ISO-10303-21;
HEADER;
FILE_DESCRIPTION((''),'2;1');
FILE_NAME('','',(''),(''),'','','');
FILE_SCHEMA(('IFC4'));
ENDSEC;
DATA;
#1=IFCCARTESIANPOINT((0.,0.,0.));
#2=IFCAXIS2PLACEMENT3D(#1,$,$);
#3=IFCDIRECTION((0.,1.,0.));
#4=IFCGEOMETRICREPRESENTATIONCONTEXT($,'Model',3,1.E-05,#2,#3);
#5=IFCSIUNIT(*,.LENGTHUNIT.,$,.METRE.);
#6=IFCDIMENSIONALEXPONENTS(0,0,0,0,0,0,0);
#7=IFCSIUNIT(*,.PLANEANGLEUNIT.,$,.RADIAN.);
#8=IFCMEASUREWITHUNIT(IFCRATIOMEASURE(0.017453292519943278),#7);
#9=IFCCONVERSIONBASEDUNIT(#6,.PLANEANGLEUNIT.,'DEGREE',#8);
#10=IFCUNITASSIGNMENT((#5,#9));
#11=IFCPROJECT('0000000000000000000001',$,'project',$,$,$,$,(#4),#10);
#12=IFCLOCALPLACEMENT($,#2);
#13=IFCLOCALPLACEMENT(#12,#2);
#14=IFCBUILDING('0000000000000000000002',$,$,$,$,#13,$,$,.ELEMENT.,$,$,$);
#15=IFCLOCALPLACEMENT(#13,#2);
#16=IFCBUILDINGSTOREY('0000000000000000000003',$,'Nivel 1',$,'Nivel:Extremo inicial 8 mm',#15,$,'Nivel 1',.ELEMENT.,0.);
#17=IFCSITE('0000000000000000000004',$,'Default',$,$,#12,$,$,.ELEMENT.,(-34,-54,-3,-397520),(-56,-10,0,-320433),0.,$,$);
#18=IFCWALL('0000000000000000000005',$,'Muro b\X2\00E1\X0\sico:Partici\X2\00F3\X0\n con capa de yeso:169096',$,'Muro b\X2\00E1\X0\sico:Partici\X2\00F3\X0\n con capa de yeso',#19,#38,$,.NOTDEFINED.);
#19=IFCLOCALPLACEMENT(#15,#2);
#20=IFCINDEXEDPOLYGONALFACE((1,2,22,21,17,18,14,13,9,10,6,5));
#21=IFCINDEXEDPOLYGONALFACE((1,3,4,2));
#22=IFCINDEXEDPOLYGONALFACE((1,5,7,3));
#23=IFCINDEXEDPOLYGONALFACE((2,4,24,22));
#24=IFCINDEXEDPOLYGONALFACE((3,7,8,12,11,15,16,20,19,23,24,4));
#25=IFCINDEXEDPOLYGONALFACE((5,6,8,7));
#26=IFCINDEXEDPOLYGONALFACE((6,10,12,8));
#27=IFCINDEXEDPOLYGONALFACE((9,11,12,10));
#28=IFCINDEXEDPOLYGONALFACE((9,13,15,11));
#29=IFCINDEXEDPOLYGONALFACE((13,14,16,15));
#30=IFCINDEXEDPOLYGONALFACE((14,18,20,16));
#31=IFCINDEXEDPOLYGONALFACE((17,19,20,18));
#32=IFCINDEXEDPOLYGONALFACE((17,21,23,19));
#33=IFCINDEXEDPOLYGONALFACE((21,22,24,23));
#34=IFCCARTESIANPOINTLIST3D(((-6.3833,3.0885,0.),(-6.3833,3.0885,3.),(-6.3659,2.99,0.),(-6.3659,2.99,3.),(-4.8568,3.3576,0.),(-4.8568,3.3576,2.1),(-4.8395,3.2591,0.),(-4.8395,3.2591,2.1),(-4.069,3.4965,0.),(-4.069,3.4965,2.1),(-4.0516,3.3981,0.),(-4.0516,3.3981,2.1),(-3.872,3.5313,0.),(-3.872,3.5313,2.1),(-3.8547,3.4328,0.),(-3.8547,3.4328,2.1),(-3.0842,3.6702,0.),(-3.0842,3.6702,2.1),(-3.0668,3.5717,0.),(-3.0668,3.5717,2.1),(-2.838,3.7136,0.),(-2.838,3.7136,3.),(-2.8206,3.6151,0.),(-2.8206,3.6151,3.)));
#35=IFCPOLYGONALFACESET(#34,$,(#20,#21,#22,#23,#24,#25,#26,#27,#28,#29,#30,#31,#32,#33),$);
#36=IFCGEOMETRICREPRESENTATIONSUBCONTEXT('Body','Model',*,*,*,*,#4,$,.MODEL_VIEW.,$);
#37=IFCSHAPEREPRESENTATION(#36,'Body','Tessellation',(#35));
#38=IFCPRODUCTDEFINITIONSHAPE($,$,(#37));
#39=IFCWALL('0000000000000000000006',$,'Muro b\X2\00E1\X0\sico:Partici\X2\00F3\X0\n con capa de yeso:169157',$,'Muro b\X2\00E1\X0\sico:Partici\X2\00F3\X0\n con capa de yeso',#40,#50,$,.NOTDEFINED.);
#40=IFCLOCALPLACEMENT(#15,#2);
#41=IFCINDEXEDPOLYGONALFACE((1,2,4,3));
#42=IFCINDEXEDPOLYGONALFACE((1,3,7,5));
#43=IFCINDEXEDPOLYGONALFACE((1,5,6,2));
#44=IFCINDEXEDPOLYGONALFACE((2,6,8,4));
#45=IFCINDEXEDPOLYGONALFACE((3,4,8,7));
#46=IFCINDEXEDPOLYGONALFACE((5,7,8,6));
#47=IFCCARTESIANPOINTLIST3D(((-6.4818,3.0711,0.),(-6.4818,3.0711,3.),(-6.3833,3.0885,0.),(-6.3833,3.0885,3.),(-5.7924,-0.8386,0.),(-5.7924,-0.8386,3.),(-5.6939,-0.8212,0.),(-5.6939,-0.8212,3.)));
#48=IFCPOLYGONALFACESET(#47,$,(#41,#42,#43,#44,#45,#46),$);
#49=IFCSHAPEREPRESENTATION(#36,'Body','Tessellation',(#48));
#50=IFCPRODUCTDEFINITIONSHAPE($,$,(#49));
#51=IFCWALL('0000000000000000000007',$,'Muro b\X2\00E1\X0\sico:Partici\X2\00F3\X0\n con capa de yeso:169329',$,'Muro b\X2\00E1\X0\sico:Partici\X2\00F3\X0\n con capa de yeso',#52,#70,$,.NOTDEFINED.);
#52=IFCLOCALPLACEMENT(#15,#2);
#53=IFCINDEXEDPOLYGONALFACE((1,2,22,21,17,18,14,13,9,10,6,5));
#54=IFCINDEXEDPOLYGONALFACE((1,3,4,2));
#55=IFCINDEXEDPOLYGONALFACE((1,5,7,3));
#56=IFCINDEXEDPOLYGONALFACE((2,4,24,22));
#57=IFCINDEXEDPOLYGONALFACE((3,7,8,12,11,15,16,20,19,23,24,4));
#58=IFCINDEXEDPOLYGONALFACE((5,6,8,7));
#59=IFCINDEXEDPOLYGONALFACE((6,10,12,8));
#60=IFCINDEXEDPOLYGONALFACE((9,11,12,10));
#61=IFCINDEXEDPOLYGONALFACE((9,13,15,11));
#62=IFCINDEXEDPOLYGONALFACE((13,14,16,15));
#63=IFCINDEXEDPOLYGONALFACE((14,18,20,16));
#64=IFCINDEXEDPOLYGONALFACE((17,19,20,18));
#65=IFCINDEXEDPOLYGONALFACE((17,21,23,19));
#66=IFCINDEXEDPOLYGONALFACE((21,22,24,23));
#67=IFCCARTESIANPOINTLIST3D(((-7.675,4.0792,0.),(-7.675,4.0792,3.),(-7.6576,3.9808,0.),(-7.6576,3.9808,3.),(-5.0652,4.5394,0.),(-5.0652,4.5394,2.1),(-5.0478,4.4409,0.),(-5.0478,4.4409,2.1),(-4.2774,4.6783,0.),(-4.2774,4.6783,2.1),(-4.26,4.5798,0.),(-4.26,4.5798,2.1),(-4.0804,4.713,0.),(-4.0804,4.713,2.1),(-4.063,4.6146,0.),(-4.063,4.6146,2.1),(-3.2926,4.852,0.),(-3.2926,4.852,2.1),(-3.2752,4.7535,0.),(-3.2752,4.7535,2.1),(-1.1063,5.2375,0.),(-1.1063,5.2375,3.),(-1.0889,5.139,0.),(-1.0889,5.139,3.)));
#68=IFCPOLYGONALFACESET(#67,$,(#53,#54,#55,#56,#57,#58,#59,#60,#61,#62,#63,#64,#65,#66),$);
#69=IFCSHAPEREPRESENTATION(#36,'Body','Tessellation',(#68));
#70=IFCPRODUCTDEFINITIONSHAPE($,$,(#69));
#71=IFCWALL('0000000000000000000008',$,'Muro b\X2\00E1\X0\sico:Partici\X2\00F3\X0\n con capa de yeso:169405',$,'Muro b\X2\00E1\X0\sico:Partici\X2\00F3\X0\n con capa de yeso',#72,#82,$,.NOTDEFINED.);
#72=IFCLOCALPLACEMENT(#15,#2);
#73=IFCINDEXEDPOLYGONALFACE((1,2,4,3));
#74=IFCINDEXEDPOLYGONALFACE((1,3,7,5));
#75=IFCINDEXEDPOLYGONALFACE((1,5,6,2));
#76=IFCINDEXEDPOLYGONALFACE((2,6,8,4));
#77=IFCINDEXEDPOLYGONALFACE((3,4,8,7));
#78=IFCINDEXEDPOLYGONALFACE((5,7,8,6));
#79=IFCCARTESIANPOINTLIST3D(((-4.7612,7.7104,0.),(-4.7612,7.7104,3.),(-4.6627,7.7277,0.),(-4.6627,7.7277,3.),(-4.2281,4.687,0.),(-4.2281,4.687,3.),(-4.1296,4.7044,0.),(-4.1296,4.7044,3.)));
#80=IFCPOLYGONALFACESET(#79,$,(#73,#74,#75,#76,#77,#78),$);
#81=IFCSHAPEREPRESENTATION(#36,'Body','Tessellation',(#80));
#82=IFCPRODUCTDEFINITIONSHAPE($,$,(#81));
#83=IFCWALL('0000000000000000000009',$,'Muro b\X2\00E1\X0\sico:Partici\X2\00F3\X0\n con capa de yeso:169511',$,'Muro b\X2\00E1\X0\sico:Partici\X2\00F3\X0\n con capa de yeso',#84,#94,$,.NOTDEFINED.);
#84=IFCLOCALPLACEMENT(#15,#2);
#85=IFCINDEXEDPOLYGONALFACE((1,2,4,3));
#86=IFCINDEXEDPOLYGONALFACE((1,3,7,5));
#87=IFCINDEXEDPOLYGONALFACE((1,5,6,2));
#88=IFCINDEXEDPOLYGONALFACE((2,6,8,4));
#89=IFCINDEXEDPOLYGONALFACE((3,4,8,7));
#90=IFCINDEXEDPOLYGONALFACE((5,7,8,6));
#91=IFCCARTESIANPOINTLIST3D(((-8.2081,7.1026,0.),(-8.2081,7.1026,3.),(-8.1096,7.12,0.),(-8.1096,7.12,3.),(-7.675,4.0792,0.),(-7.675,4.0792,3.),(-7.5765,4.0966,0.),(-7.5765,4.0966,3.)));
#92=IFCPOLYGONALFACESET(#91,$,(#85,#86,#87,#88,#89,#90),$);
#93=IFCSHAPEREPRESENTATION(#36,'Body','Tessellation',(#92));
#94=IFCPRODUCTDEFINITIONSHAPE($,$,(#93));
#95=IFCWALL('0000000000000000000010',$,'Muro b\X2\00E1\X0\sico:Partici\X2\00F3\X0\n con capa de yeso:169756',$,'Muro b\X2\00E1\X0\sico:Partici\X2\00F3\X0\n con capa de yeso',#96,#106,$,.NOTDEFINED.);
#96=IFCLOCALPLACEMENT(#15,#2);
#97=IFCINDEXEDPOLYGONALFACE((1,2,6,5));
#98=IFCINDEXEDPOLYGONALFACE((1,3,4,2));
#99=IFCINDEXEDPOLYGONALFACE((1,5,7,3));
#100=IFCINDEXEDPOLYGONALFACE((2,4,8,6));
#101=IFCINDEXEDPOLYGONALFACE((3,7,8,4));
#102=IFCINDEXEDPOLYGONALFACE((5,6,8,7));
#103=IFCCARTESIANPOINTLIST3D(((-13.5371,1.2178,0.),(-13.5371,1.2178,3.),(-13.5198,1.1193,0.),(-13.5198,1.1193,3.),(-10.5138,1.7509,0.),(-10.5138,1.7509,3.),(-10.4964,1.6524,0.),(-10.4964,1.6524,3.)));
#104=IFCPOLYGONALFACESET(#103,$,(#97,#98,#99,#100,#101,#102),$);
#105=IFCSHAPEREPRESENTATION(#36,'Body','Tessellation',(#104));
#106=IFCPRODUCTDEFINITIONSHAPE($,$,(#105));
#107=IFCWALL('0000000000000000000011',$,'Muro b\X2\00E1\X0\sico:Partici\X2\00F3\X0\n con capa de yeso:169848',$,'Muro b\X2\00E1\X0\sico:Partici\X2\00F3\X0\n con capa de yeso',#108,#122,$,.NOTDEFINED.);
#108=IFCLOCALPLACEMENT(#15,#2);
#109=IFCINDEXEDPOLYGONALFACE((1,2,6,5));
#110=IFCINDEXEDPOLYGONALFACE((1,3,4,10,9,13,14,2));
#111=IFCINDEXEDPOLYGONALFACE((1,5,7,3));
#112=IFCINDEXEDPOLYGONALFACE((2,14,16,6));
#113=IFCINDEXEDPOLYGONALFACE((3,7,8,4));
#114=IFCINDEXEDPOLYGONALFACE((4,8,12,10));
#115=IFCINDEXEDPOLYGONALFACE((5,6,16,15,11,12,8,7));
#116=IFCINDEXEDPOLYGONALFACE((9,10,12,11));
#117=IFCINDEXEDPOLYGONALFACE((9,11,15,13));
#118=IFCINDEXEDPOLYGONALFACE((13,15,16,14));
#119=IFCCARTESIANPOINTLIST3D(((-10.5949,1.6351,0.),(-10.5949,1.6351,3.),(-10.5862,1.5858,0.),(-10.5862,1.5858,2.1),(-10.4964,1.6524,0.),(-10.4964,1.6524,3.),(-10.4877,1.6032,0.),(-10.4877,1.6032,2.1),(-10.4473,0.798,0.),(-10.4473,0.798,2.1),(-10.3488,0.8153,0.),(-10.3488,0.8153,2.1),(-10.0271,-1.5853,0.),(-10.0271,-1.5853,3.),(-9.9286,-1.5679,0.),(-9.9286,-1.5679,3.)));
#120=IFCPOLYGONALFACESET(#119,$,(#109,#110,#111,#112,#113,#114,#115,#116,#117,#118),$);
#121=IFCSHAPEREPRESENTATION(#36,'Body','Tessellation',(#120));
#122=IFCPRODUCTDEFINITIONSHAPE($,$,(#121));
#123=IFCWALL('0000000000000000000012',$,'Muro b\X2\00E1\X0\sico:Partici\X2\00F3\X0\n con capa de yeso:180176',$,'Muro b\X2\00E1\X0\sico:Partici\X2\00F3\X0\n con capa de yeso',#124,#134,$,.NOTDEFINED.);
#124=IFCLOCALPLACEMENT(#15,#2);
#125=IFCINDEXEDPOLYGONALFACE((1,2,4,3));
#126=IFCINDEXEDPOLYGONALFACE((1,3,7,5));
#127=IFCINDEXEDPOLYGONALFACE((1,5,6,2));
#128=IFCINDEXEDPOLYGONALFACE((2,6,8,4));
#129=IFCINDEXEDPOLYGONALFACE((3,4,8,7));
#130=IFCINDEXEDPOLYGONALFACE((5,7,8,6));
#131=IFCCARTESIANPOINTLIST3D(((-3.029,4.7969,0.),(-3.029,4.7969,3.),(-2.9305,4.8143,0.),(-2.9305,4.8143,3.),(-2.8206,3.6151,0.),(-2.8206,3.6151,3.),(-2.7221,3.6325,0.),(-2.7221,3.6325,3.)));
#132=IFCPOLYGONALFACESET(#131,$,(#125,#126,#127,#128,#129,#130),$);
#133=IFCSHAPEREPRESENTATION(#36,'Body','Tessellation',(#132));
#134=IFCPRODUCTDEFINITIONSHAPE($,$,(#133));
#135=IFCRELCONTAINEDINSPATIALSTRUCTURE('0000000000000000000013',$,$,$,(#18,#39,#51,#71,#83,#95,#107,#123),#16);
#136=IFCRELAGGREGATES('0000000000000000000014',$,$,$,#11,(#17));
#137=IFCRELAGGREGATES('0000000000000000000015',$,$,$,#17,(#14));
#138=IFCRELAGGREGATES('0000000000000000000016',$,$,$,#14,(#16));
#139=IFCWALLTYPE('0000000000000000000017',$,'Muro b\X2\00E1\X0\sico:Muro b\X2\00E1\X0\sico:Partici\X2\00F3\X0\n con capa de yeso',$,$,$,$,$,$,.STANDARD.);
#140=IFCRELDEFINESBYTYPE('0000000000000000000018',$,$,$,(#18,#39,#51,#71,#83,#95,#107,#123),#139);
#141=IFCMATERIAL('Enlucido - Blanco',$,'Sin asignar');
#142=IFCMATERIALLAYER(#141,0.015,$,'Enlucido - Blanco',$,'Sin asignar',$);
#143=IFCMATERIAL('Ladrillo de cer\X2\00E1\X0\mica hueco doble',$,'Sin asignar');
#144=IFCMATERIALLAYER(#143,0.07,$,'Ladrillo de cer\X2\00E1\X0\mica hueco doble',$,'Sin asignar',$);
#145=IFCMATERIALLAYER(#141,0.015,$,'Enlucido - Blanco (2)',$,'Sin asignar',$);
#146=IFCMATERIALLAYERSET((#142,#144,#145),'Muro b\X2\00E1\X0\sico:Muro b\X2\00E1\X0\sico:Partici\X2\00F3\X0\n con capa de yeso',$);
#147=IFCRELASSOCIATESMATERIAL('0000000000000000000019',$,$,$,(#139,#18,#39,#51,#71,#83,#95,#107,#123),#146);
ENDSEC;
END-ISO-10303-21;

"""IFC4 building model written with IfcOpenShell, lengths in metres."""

from ifc_helpers import new_model, entity, si_unit, converted_unit, direction, frame, frame_2d, origin, origin_2d_with_axis, place, context, subcontext, project, spatial, rectangle, extrude, material, layer, layer_set, layer_usage, type_object, element, save


model = new_model("IFC4")

# Units and contexts
model_context = context("Model", 3, precision=1e-05, world=origin(), true_north=direction((0.0, 1.0, 0.0)))
body_context = subcontext(model_context, "Body", "Model", "MODEL_VIEW")
ifc_project = project(units=[si_unit("LENGTHUNIT", "METRE"), converted_unit("PLANEANGLEUNIT", "DEGREE", entity("IfcRatioMeasure", 0.017453292519943278), si_unit("PLANEANGLEUNIT", "RADIAN"), dimensions=[0, 0, 0, 0, 0, 0, 0])], contexts=[model_context])

# Site, building, storey
site_placement = place(None, origin())
site = spatial("IfcSite", under=ifc_project, at=site_placement, Name="Default", CompositionType="ELEMENT", RefLatitude=(-34, -54, -3, -397520), RefLongitude=(-56, -10, 0, -320433), RefElevation=0.0)
building_placement = place(site_placement, origin())
building = spatial("IfcBuilding", under=site, at=building_placement, CompositionType="ELEMENT")
storey_placement = place(building_placement, origin())
storey = spatial("IfcBuildingStorey", under=building, at=storey_placement, Name="Nivel 1", ObjectType="Nivel:Extremo inicial 8 mm", LongName="Nivel 1", CompositionType="ELEMENT", Elevation=0.0)

# Shared definitions
ifc_material_1 = material(Name="Enlucido - Blanco", Category="Sin asignar")
ifc_layer_1 = layer(ifc_material_1, 0.015, Name="Enlucido - Blanco", Category="Sin asignar")
ifc_material_2 = material(Name="Ladrillo de cerámica hueco doble", Category="Sin asignar")
ifc_layer_2 = layer(ifc_material_2, 0.07, Name="Ladrillo de cerámica hueco doble", Category="Sin asignar")
ifc_layer_3 = layer(ifc_material_1, 0.015, Name="Enlucido - Blanco (2)", Category="Sin asignar")
ifc_layer_set_1 = layer_set([ifc_layer_1, ifc_layer_2, ifc_layer_3], Name="Muro básico:Muro básico:Partición con capa de yeso")
ifc_layer_usage_1 = layer_usage(ifc_layer_set_1, "AXIS2", "NEGATIVE", 0.05)
wall_type_1 = type_object("IfcWallType", Name="Muro básico:Muro básico:Partición con capa de yeso", PredefinedType="STANDARD", material=ifc_layer_set_1)

# Wall, openings
wall_1_placement = place(storey_placement, frame((-6.3746, 3.0392, 0.0), z_axis=(0.0, 0.0, 1.0), x_axis=(0.984808, 0.173648, 0.0)))
wall_1 = element("IfcWall", 1, at=wall_1_placement, inside=storey, type_object=wall_type_1, material=ifc_layer_usage_1, Name="Muro básico:Partición con capa de yeso:169096", ObjectType="Muro básico:Partición con capa de yeso", PredefinedType="NOTDEFINED", context=body_context, shape_type="SweptSolid", body=[
    extrude(rectangle(XDim=3.6, YDim=0.1, at=frame_2d((1.8, 0.0), x_axis=(-1.0, 0.0))), origin(), (0.0, 0.0, 1.0), 3.0),
])
opening_1_placement = place(wall_1_placement, frame((2.5326, -0.0479, 0.0), z_axis=(0.0, 0.0, 1.0), x_axis=(0.984808, -0.173648, 0.0)))
element("IfcOpeningElement", 2, at=opening_1_placement, cuts=wall_1, PredefinedType="OPENING", context=body_context, shape_type="SweptSolid", body=[
    extrude(rectangle(XDim=2.1, YDim=0.8, at=origin_2d_with_axis()), frame((0.4116, 0.0695, 1.05), z_axis=(-0.173648, 0.984808, 0.0), x_axis=(0.0, 0.0, -1.0)), (0.0, 0.0, 1.0), 0.102),
])
opening_2_placement = place(wall_1_placement, frame((1.5326, -0.0479, 0.0), z_axis=(0.0, 0.0, 1.0), x_axis=(0.984808, -0.173648, 0.0)))
element("IfcOpeningElement", 3, at=opening_2_placement, cuts=wall_1, PredefinedType="OPENING", context=body_context, shape_type="SweptSolid", body=[
    extrude(rectangle(XDim=2.1, YDim=0.8, at=frame_2d((0.0, 0.0), x_axis=(1.0, 0.0))), frame((0.4116, 0.0695, 1.05), z_axis=(-0.173648, 0.984808, 0.0), x_axis=(0.0, 0.0, -1.0)), (0.0, 0.0, 1.0), 0.102),
])

# Wall
wall_2_placement = place(storey_placement, frame((-5.7431, -0.8299, 0.0), z_axis=(0.0, 0.0, 1.0), x_axis=(-0.173648, 0.984808, 0.0)))
element("IfcWall", 4, at=wall_2_placement, inside=storey, type_object=wall_type_1, material=ifc_layer_usage_1, Name="Muro básico:Partición con capa de yeso:169157", ObjectType="Muro básico:Partición con capa de yeso", PredefinedType="NOTDEFINED", context=body_context, shape_type="SweptSolid", body=[
    extrude(rectangle(XDim=3.97, YDim=0.1, at=frame_2d((1.985, 0.0), x_axis=(-1.0, 0.0))), origin(), (0.0, 0.0, 1.0), 3.0),
])

# Wall, openings
wall_3_placement = place(storey_placement, frame((-1.0976, 5.1882, 0.0), z_axis=(0.0, 0.0, 1.0), x_axis=(-0.984808, -0.173648, 0.0)))
wall_3 = element("IfcWall", 5, at=wall_3_placement, inside=storey, type_object=wall_type_1, material=ifc_layer_usage_1, Name="Muro básico:Partición con capa de yeso:169329", ObjectType="Muro básico:Partición con capa de yeso", PredefinedType="NOTDEFINED", context=body_context, shape_type="SweptSolid", body=[
    extrude(rectangle(XDim=6.67, YDim=0.1, at=frame_2d((3.335, 0.0), x_axis=(-1.0, 0.0))), origin(), (0.0, 0.0, 1.0), 3.0),
])
opening_3_placement = place(wall_3_placement, frame((4.0374, 0.0479, 0.0), z_axis=(0.0, 0.0, 1.0), x_axis=(-0.984808, 0.173648, 0.0)))
element("IfcOpeningElement", 6, at=opening_3_placement, cuts=wall_3, PredefinedType="OPENING", context=body_context, shape_type="SweptSolid", body=[
    extrude(rectangle(XDim=2.1, YDim=0.8, at=frame_2d((0.0, 0.0), x_axis=(1.0, 0.0))), frame((0.3939, 0.1699, 1.05), z_axis=(0.173648, -0.984808, 0.0), x_axis=(0.0, 0.0, -1.0)), (0.0, 0.0, 1.0), 0.102),
])
opening_4_placement = place(wall_3_placement, frame((3.0374, 0.0479, 0.0), z_axis=(0.0, 0.0, 1.0), x_axis=(-0.984808, 0.173648, 0.0)))
element("IfcOpeningElement", 7, at=opening_4_placement, cuts=wall_3, PredefinedType="OPENING", context=body_context, shape_type="SweptSolid", body=[
    extrude(rectangle(XDim=2.1, YDim=0.8, at=frame_2d((0.0, 0.0), x_axis=(1.0, 0.0))), frame((0.3939, 0.1699, 1.05), z_axis=(0.173648, -0.984808, 0.0), x_axis=(0.0, 0.0, -1.0)), (0.0, 0.0, 1.0), 0.102),
])

# Walls
wall_4_placement = place(storey_placement, frame((-4.1789, 4.6957, 0.0), z_axis=(0.0, 0.0, 1.0), x_axis=(-0.173648, 0.984808, 0.0)))
element("IfcWall", 8, at=wall_4_placement, inside=storey, type_object=wall_type_1, material=ifc_layer_usage_1, Name="Muro básico:Partición con capa de yeso:169405", ObjectType="Muro básico:Partición con capa de yeso", PredefinedType="NOTDEFINED", context=body_context, shape_type="SweptSolid", body=[
    extrude(rectangle(XDim=3.07, YDim=0.1, at=frame_2d((1.535, 0.0), x_axis=(-1.0, 0.0))), origin(), (0.0, 0.0, 1.0), 3.0),
])
wall_5_placement = place(storey_placement, frame((-7.6257, 4.0879, 0.0), z_axis=(0.0, 0.0, 1.0), x_axis=(-0.173648, 0.984808, 0.0)))
element("IfcWall", 9, at=wall_5_placement, inside=storey, type_object=wall_type_1, material=ifc_layer_usage_1, Name="Muro básico:Partición con capa de yeso:169511", ObjectType="Muro básico:Partición con capa de yeso", PredefinedType="NOTDEFINED", context=body_context, shape_type="SweptSolid", body=[
    extrude(rectangle(XDim=3.07, YDim=0.1, at=frame_2d((1.535, 0.0), x_axis=(-1.0, 0.0))), origin(), (0.0, 0.0, 1.0), 3.0),
])
wall_6_placement = place(storey_placement, frame((-13.5284, 1.1686, 0.0), z_axis=(0.0, 0.0, 1.0), x_axis=(0.984808, 0.173648, 0.0)))
element("IfcWall", 10, at=wall_6_placement, inside=storey, type_object=wall_type_1, material=ifc_layer_usage_1, Name="Muro básico:Partición con capa de yeso:169756", ObjectType="Muro básico:Partición con capa de yeso", PredefinedType="NOTDEFINED", context=body_context, shape_type="SweptSolid", body=[
    extrude(rectangle(XDim=3.07, YDim=0.1, at=frame_2d((1.535, 0.0), x_axis=(-1.0, 0.0))), origin(), (0.0, 0.0, 1.0), 3.0),
])

# Wall, opening
wall_7_placement = place(storey_placement, frame((-10.5456, 1.6437, 0.0), z_axis=(0.0, 0.0, 1.0), x_axis=(0.173648, -0.984808, 0.0)))
wall_7 = element("IfcWall", 11, at=wall_7_placement, inside=storey, type_object=wall_type_1, material=ifc_layer_usage_1, Name="Muro básico:Partición con capa de yeso:169848", ObjectType="Muro básico:Partición con capa de yeso", PredefinedType="NOTDEFINED", context=body_context, shape_type="SweptSolid", body=[
    extrude(rectangle(XDim=3.27, YDim=0.1, at=frame_2d((1.635, 0.0), x_axis=(1.0, 0.0))), origin(), (0.0, 0.0, 1.0), 3.0),
])
opening_5_placement = place(wall_7_placement, frame((0.8259, -0.1878, 0.0), z_axis=(0.0, 0.0, 1.0), x_axis=(0.173648, 0.984808, 0.0)))
element("IfcOpeningElement", 12, at=opening_5_placement, cuts=wall_7, PredefinedType="OPENING", context=body_context, shape_type="SweptSolid", body=[
    extrude(rectangle(XDim=2.1, YDim=0.8, at=frame_2d((0.0, 0.0), x_axis=(1.0, 0.0))), frame((0.0695, 0.3939, 1.05), z_axis=(0.984808, 0.173648, 0.0), x_axis=(0.0, 0.0, -1.0)), (0.0, 0.0, 1.0), 0.102),
])

# Wall
wall_8_placement = place(storey_placement, frame((-2.7714, 3.6238, 0.0), z_axis=(0.0, 0.0, 1.0), x_axis=(-0.173648, 0.984808, 0.0)))
element("IfcWall", 13, at=wall_8_placement, inside=storey, type_object=wall_type_1, material=ifc_layer_usage_1, Name="Muro básico:Partición con capa de yeso:180176", ObjectType="Muro básico:Partición con capa de yeso", PredefinedType="NOTDEFINED", context=body_context, shape_type="SweptSolid", body=[
    extrude(rectangle(XDim=1.2, YDim=0.1, at=frame_2d((0.6, 0.0), x_axis=(-1.0, 0.0))), origin(), (0.0, 0.0, 1.0), 3.0),
])

save(model, "model.ifc")
